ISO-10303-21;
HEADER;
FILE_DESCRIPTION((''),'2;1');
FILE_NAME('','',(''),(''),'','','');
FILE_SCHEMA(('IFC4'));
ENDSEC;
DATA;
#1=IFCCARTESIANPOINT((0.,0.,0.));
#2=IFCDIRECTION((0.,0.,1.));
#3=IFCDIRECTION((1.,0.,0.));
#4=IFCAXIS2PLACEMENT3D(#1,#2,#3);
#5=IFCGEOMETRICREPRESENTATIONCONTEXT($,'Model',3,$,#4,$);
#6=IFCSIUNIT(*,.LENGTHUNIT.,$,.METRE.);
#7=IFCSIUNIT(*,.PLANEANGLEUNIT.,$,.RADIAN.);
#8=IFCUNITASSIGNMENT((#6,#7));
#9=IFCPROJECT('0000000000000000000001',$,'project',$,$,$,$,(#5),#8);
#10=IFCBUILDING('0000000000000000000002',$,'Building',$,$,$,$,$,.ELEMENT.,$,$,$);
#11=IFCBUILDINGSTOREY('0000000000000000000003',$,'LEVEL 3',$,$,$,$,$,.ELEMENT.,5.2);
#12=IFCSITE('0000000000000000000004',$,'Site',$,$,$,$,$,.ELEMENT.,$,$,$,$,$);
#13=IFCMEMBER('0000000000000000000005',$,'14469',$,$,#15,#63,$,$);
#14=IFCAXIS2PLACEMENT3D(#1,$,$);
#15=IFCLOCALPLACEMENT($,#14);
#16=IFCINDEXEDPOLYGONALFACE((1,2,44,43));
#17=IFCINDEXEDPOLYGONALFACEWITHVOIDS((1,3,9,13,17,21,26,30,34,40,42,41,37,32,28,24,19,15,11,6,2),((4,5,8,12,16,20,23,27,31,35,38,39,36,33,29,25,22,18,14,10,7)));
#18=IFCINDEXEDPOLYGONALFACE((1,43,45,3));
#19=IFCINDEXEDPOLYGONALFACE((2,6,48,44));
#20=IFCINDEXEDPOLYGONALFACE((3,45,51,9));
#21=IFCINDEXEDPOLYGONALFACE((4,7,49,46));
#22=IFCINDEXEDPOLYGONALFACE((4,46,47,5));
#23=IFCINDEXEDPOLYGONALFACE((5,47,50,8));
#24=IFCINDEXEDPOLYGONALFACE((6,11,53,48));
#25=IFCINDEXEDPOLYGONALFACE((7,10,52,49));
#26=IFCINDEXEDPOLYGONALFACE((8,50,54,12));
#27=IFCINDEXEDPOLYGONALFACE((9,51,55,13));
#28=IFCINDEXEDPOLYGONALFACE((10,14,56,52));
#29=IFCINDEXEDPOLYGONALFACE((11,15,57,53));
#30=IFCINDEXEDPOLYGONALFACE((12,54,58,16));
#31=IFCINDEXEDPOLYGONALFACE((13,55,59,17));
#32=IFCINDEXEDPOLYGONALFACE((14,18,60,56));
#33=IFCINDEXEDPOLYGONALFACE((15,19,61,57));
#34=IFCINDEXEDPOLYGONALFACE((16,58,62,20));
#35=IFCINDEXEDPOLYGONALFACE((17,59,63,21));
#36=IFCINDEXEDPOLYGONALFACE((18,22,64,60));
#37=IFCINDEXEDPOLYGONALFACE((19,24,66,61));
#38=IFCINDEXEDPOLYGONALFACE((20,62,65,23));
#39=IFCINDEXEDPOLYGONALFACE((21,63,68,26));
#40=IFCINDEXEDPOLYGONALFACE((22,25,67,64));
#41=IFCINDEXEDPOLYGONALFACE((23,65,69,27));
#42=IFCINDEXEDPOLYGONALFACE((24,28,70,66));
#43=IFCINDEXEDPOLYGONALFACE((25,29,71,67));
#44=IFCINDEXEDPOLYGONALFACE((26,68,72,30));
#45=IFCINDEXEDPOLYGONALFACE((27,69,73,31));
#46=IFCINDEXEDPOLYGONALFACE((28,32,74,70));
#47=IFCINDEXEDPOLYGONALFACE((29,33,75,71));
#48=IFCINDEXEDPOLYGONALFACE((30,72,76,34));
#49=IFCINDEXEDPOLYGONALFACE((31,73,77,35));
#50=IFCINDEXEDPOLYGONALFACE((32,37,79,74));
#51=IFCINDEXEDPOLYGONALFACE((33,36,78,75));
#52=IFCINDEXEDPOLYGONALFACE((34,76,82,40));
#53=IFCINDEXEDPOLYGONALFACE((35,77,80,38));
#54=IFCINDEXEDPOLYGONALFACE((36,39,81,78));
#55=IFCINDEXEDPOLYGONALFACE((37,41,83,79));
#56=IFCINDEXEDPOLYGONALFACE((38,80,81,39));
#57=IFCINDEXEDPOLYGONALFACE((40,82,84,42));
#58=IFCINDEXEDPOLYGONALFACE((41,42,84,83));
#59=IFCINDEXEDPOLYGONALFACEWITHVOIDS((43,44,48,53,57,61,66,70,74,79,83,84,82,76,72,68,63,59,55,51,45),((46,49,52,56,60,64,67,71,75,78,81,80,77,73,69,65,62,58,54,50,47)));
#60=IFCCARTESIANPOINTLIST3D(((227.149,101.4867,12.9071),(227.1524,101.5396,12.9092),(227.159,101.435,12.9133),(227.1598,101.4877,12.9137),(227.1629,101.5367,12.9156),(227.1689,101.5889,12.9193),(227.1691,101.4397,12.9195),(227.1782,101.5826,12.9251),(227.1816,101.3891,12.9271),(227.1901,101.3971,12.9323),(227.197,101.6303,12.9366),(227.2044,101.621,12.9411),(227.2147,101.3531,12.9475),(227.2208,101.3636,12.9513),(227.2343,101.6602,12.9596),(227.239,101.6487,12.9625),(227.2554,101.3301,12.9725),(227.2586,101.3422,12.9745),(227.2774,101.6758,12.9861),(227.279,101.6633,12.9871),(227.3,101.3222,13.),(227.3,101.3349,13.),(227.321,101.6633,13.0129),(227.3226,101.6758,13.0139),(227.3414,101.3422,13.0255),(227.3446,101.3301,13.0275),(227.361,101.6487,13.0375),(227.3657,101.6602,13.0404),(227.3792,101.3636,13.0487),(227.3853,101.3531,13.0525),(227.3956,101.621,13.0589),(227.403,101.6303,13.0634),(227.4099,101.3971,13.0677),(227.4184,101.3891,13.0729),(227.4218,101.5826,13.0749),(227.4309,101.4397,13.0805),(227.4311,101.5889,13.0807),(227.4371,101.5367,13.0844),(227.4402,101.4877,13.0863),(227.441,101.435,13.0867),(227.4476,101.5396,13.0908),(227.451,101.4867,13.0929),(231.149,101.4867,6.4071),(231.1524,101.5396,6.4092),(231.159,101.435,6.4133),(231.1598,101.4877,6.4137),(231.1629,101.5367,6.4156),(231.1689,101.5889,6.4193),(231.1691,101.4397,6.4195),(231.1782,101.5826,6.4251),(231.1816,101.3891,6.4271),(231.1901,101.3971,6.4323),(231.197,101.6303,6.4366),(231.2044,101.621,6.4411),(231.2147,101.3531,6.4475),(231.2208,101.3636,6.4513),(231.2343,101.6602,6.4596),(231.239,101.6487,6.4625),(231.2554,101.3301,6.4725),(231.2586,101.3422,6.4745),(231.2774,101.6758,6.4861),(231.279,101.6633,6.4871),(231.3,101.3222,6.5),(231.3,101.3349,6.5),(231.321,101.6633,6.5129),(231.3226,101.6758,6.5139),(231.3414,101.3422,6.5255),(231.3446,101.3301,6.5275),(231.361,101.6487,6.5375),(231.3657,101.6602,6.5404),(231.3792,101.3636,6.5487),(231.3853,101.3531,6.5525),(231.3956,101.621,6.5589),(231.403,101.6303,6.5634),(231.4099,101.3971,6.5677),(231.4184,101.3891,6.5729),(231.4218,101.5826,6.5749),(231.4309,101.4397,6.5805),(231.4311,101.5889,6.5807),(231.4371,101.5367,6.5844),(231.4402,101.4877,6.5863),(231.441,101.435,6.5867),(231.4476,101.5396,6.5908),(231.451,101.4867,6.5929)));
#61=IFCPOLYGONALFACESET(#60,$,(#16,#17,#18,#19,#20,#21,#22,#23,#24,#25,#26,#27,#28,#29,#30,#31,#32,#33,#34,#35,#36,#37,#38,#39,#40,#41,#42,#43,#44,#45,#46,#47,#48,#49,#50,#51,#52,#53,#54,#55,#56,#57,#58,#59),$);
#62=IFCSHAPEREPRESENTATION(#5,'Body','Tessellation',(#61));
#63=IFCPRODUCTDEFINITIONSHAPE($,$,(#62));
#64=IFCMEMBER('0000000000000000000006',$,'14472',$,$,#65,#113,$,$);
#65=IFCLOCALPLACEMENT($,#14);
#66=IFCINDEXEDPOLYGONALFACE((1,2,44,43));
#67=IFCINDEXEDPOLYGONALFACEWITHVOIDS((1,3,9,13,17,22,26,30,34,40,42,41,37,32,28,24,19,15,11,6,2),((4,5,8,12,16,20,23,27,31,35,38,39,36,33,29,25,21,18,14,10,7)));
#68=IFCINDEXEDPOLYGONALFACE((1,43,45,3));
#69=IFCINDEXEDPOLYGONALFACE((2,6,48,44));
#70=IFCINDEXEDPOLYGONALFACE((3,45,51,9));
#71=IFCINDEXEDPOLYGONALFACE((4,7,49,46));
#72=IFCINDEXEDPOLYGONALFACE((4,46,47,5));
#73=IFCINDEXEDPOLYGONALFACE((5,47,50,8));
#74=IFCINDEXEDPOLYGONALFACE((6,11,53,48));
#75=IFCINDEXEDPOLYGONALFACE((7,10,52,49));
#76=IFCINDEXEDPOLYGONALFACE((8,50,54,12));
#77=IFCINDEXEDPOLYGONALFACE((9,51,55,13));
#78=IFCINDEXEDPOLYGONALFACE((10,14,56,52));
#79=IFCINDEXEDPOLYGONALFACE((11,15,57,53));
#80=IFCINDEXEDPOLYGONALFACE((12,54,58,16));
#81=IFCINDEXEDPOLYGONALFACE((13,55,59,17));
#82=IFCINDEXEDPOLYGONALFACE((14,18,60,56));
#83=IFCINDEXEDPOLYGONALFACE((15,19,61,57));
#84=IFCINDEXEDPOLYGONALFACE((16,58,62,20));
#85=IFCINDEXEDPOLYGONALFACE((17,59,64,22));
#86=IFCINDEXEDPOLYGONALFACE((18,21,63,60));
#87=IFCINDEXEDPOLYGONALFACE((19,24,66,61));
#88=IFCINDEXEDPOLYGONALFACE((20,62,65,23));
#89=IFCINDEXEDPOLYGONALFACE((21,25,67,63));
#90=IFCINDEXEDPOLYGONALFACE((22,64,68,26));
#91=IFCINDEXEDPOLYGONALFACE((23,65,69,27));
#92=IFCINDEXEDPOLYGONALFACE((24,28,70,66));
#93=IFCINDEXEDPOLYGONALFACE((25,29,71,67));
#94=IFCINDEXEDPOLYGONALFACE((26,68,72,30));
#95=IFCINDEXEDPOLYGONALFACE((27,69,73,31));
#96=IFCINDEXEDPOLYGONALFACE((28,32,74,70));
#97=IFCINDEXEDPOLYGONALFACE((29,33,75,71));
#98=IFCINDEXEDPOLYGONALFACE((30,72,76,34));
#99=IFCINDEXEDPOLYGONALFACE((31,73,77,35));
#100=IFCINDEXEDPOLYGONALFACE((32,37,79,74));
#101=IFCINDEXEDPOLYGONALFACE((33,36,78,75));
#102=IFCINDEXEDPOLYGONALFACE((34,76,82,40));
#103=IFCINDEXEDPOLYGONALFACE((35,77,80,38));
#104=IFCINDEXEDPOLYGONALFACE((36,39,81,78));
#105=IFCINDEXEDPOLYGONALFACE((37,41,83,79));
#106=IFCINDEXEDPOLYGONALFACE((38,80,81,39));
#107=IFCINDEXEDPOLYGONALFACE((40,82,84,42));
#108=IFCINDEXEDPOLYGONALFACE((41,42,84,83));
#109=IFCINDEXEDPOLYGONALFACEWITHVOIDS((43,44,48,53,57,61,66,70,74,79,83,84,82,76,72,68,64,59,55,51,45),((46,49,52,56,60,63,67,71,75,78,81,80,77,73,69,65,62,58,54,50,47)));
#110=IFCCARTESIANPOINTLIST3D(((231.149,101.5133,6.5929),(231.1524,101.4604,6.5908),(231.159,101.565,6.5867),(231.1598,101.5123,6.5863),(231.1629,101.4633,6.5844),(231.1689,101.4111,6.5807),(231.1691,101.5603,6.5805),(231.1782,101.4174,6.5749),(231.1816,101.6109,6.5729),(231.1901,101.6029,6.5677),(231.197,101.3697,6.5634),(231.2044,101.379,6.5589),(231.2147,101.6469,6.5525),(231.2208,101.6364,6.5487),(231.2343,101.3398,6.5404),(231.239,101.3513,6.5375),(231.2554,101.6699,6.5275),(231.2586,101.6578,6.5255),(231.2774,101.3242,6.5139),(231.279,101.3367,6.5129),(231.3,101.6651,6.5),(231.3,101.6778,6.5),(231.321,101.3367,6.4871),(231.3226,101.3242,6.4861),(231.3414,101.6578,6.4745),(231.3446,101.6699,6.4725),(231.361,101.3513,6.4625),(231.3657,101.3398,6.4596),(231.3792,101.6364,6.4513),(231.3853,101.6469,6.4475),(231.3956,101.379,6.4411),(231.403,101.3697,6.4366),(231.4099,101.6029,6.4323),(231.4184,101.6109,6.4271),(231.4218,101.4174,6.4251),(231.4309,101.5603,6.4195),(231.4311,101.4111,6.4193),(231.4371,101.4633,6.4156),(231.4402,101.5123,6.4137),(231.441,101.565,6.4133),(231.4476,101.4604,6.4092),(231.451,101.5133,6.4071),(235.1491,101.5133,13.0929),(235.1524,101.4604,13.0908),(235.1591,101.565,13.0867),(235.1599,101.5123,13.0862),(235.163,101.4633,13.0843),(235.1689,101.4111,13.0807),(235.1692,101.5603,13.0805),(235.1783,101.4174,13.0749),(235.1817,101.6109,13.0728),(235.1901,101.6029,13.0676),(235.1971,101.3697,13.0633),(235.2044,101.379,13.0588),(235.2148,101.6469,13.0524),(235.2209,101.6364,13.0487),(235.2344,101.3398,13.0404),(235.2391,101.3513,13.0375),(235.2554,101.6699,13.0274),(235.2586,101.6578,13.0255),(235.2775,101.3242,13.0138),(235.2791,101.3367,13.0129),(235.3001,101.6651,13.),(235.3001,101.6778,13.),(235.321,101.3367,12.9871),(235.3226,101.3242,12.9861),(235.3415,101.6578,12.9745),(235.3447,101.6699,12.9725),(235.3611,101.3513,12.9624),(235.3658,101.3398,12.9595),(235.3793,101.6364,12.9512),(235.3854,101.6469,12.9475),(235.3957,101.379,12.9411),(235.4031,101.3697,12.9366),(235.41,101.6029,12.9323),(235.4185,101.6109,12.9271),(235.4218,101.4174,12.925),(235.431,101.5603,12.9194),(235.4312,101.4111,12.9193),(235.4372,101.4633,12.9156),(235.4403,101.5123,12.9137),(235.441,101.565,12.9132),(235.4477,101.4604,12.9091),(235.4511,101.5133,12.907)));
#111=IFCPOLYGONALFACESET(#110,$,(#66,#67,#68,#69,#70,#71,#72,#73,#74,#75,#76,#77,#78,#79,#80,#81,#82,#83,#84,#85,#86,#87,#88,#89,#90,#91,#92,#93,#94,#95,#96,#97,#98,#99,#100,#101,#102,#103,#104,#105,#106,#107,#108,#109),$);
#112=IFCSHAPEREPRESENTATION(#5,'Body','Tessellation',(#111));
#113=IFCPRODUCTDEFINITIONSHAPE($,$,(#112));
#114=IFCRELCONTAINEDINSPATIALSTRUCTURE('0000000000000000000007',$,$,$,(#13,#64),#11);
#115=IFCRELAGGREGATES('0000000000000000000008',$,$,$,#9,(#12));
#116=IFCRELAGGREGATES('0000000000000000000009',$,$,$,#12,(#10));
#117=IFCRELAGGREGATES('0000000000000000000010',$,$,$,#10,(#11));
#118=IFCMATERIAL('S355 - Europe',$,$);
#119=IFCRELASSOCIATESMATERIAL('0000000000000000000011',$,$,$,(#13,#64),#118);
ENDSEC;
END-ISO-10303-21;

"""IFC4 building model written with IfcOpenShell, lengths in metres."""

from ifc_helpers import new_model, si_unit, frame, origin_with_axes, origin_2d_with_axis, place, context, project, spatial, hollow_circle, extrude, material, material_profile, profile_set, profile_usage, element, save


model = new_model("IFC4")

# Units and contexts
model_context = context("Model", 3, world=origin_with_axes())
ifc_project = project(units=[si_unit("LENGTHUNIT", "METRE"), si_unit("PLANEANGLEUNIT", "RADIAN")], contexts=[model_context])

# Site, building, storey
site = spatial("IfcSite", under=ifc_project, Name="Site", CompositionType="ELEMENT")
building = spatial("IfcBuilding", under=site, Name="Building", CompositionType="ELEMENT")
storey = spatial("IfcBuildingStorey", under=building, Name="LEVEL 3", CompositionType="ELEMENT", Elevation=5.2)

# Shared definitions
ifc_material = material(Name="S355 - Europe")

# Members
ifc_material_profile_1 = material_profile(ifc_material, hollow_circle(Radius=0.1778, WallThickness=0.0127, at=origin_2d_with_axis()))
ifc_profile_set_1 = profile_set([ifc_material_profile_1])
ifc_profile_usage_1 = profile_usage(ifc_profile_set_1, cardinal=10)
member_1_placement = place(None, frame((231.3, 101.5, 6.5), z_axis=(-0.524097, 0.0, 0.851658), x_axis=(0.0, -1.0, 0.0)))
element("IfcMember", 1, at=member_1_placement, inside=storey, material=ifc_profile_usage_1, Name="14469", context=model_context, shape_type="SweptSolid", body=[
    extrude(hollow_circle(Radius=0.1778, WallThickness=0.0127, at=origin_2d_with_axis()), origin_with_axes(), (0.0, 0.0, 1.0), 7.6322),
])
ifc_material_profile_2 = material_profile(ifc_material, hollow_circle(Radius=0.1778, WallThickness=0.0127, at=origin_2d_with_axis()))
ifc_profile_set_2 = profile_set([ifc_material_profile_2])
ifc_profile_usage_2 = profile_usage(ifc_profile_set_2, cardinal=10)
member_2_placement = place(None, frame((231.3, 101.5, 6.5), z_axis=(0.524107, 0.0, 0.851652), x_axis=(0.0, 1.0, 0.0)))
element("IfcMember", 2, at=member_2_placement, inside=storey, material=ifc_profile_usage_2, Name="14472", context=model_context, shape_type="SweptSolid", body=[
    extrude(hollow_circle(Radius=0.1778, WallThickness=0.0127, at=origin_2d_with_axis()), origin_with_axes(), (0.0, 0.0, 1.0), 7.6322),
])

save(model, "model.ifc")
